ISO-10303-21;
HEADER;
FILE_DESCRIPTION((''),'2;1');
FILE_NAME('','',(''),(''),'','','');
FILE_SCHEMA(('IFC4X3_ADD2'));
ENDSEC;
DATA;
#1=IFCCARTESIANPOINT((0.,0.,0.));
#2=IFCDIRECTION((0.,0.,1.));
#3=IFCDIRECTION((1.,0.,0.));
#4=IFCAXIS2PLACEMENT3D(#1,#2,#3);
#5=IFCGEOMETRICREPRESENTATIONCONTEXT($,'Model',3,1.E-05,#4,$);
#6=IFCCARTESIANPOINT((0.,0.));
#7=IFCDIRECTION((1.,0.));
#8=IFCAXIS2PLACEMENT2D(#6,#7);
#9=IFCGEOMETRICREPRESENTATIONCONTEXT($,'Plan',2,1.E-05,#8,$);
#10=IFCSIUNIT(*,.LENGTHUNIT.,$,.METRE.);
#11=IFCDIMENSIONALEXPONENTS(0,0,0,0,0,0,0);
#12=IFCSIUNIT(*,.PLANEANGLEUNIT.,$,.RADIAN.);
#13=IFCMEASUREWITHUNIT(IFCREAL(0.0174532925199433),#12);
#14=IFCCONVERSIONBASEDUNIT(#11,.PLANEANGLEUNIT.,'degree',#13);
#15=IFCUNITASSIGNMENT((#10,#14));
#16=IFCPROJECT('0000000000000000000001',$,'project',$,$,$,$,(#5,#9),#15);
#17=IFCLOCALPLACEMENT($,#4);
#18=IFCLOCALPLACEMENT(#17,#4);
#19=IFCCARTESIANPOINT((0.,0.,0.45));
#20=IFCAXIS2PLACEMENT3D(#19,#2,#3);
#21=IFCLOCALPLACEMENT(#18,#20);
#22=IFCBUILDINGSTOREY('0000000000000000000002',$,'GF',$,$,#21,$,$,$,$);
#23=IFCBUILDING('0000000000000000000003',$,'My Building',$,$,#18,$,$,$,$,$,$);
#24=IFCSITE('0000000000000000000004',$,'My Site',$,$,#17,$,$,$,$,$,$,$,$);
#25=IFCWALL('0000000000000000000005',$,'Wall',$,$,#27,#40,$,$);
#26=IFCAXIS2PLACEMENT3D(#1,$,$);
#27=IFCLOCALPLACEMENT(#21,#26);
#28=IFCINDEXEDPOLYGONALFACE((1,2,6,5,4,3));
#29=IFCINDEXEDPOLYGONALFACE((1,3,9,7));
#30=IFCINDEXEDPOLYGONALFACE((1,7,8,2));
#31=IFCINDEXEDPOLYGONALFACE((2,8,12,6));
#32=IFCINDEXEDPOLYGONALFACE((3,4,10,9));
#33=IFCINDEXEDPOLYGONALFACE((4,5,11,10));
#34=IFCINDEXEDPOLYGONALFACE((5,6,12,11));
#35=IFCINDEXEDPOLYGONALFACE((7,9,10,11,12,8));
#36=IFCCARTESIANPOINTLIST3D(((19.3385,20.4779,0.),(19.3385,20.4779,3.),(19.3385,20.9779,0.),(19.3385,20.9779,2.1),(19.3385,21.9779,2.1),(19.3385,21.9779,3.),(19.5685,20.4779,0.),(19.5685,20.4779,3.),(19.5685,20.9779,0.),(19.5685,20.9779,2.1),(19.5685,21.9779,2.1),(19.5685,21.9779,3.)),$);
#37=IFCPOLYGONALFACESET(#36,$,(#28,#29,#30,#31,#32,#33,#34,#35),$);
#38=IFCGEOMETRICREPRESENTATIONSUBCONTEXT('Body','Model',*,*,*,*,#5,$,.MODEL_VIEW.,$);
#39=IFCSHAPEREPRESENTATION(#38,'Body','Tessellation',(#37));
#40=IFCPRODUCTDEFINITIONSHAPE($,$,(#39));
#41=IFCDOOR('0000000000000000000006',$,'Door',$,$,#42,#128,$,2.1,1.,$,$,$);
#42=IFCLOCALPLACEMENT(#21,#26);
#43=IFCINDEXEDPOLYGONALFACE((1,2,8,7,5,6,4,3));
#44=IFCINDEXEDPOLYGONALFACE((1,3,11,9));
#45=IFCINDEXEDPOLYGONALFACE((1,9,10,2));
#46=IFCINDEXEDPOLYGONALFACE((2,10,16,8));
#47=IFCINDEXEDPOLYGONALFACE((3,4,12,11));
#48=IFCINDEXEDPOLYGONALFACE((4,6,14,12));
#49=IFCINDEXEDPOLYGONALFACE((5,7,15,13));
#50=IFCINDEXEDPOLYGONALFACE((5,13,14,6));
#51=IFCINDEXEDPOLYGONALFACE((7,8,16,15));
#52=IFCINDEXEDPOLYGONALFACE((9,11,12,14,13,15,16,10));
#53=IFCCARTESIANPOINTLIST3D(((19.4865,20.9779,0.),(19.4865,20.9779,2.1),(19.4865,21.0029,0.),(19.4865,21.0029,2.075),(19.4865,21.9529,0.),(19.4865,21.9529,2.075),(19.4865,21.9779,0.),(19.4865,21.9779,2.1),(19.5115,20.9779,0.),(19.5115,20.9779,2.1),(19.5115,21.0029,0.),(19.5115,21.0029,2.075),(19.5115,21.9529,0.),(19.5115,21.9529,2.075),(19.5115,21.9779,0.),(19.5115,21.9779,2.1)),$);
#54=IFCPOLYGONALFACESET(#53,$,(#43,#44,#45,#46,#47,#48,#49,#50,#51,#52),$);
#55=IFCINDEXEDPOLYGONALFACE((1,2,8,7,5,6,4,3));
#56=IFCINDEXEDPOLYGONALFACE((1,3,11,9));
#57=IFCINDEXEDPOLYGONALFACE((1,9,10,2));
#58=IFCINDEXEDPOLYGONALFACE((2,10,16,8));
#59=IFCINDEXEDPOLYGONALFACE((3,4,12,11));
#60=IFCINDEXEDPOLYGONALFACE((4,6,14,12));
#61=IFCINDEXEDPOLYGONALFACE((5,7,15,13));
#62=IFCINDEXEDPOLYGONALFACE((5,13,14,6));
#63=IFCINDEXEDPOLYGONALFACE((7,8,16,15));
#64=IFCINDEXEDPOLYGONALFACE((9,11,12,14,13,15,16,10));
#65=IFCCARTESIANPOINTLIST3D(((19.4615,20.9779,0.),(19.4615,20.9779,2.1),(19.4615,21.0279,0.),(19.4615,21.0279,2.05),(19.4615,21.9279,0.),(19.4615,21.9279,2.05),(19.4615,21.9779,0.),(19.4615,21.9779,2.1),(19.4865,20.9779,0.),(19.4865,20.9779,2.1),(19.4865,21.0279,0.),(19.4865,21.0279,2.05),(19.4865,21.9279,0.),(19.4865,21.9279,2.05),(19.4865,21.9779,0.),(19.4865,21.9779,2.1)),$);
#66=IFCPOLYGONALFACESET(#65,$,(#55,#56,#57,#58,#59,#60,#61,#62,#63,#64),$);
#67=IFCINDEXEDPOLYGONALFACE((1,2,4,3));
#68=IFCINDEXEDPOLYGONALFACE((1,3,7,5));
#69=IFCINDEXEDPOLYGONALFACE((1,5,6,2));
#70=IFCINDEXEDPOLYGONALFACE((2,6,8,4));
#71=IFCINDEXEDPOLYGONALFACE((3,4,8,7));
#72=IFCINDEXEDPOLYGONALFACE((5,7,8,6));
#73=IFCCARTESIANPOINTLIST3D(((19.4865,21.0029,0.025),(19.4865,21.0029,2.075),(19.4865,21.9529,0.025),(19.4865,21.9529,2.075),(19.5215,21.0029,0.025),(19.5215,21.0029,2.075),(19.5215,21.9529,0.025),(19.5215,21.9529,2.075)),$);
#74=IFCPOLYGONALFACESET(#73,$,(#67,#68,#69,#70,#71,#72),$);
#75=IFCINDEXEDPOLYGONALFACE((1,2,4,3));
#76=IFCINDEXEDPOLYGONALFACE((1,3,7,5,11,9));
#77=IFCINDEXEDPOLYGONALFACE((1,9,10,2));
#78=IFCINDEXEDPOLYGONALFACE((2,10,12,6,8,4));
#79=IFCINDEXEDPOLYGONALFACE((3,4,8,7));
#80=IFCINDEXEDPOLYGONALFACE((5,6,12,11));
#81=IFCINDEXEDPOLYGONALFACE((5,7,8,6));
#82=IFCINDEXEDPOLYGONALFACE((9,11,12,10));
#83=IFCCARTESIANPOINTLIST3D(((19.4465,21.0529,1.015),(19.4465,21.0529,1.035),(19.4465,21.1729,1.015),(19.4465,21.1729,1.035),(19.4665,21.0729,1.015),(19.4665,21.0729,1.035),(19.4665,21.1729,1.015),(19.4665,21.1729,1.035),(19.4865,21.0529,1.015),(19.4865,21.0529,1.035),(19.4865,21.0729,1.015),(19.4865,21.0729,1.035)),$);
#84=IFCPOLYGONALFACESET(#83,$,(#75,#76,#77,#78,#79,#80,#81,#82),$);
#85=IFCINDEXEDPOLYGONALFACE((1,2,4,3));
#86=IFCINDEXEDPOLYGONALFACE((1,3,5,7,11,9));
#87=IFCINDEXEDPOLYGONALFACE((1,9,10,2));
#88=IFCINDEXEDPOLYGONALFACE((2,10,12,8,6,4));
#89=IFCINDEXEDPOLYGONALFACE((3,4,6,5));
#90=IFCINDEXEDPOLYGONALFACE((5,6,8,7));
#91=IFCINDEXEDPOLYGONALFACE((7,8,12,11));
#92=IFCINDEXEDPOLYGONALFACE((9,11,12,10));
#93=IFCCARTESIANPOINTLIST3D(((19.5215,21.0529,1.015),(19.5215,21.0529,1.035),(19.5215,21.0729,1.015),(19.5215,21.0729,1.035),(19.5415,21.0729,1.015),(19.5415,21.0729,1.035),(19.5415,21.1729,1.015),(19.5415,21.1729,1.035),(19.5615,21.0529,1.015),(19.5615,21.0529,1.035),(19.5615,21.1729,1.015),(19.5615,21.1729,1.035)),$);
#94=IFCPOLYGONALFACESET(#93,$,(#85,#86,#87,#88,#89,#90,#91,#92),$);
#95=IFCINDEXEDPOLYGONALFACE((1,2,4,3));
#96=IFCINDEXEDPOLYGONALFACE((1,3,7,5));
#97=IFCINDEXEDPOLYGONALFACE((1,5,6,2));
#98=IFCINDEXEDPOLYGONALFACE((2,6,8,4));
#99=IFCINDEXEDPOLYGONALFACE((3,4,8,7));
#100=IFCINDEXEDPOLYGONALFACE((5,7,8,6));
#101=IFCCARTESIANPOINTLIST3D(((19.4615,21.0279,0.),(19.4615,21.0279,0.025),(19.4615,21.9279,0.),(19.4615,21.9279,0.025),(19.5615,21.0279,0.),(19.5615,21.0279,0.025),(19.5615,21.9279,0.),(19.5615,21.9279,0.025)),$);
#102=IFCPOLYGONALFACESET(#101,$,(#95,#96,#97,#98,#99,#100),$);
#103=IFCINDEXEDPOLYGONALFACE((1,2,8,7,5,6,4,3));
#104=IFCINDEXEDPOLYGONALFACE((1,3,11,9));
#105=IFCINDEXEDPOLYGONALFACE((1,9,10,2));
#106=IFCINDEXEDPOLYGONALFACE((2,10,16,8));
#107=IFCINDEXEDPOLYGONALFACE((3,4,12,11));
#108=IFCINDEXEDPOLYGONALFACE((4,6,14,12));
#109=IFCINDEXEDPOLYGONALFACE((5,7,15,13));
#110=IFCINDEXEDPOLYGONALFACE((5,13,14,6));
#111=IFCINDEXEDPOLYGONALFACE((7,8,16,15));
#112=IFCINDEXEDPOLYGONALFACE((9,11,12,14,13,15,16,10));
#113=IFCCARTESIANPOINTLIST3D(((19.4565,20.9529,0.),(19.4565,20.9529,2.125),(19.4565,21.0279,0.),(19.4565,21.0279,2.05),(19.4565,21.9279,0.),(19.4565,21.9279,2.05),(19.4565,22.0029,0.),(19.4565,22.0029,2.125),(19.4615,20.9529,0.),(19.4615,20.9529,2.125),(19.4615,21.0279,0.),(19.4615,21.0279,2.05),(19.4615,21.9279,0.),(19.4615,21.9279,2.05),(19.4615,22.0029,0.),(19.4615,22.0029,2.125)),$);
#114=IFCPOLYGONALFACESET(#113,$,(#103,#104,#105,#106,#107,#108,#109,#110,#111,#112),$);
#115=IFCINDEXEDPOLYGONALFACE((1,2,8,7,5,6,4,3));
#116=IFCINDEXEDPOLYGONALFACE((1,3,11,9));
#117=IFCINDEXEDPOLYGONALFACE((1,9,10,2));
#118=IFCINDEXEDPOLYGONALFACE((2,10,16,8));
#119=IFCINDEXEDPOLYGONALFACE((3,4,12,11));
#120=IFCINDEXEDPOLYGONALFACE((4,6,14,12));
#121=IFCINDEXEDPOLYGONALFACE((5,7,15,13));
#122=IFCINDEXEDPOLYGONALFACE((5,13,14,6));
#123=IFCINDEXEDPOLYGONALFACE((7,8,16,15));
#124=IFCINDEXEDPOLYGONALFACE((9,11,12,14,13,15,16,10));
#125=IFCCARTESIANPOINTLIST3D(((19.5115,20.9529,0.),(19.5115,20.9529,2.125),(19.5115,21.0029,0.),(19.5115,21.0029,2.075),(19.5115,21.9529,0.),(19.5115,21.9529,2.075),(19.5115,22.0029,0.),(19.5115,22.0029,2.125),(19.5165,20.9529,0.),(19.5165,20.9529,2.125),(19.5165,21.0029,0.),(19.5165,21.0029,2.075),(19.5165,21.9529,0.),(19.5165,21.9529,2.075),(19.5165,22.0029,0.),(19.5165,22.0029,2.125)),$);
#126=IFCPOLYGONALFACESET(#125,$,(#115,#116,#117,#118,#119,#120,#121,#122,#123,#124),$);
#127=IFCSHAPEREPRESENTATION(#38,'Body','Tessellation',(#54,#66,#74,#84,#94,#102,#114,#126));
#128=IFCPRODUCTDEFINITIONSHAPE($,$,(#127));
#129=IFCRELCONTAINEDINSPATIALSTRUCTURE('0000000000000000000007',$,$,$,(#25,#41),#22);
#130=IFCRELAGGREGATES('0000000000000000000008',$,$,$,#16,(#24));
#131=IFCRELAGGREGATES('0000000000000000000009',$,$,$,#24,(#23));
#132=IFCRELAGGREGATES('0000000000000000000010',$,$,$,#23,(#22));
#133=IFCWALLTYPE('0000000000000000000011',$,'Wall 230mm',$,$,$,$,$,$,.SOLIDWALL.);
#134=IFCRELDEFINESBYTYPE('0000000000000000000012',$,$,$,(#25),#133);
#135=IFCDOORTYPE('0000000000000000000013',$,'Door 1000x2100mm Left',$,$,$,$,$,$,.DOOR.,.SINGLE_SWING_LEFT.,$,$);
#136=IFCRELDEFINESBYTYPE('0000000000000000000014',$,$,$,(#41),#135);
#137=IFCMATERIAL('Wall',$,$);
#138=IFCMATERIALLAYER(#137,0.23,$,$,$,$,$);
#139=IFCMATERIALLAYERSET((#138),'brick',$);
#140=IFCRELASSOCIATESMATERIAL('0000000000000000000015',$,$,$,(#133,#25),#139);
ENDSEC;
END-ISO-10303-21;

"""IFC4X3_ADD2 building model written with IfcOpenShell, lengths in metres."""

from ifc_helpers import new_model, entity, si_unit, converted_unit, frame, origin_with_axes, origin_2d_with_axis, place, context, subcontext, project, spatial, line, indexed_curve, outline, extrude, shape, source, transform, mapped, material, layer, layer_set, layer_usage, type_object, type_shapes, element, fill, save


model = new_model("IFC4X3_ADD2")

# Units and contexts
model_context = context("Model", 3, precision=1e-05, world=origin_with_axes())
plan_context = context("Plan", 2, precision=1e-05, world=origin_2d_with_axis())
body_context_1 = subcontext(model_context, "Body", "Model", "MODEL_VIEW")
body_context_2 = subcontext(plan_context, "Body", "Plan", "PLAN_VIEW")
ifc_project = project(units=[si_unit("LENGTHUNIT", "METRE"), converted_unit("PLANEANGLEUNIT", "degree", entity("IfcReal", 0.0174532925199433), si_unit("PLANEANGLEUNIT", "RADIAN"), dimensions=[0, 0, 0, 0, 0, 0, 0])], contexts=[model_context, plan_context])

# Site, building, storey
site_placement = place(None, origin_with_axes())
site = spatial("IfcSite", under=ifc_project, at=site_placement, Name="My Site")
building_placement = place(site_placement, origin_with_axes())
building = spatial("IfcBuilding", under=site, at=building_placement, Name="My Building")
storey_placement = place(building_placement, frame((0.0, 0.0, 0.45), z_axis=(0.0, 0.0, 1.0), x_axis=(1.0, 0.0, 0.0)))
storey = spatial("IfcBuildingStorey", under=building, at=storey_placement, Name="GF")

# Shared definitions
ifc_material_1 = material(Name="Wall")
ifc_layer = layer(ifc_material_1, 0.23)
ifc_layer_set = layer_set([ifc_layer], Name="brick")
wall_type = type_object("IfcWallType", Name="Wall 230mm", PredefinedType="SOLIDWALL", material=ifc_layer_set)

# Shared definitions
shared_shape_1 = source(origin_with_axes(), body_context_1, "Body", "SweptSolid", [
    extrude(outline(indexed_curve([(0.0, 0.0), (1.0, 0.0), (1.0, 2.1), (0.0, 2.1)], segments=[line(1, 2, 3, 4, 1)])), frame((0.0, -0.6, 0.0), z_axis=(0.0, -1.0, 0.0), x_axis=(1.0, 0.0, 0.0)), (0.0, 0.0, -1.0), 1.2),
])
door_type_1 = type_object("IfcDoorType", Name="Door 1000x2100mm Left", OperationType="SINGLE_SWING_LEFT", PredefinedType="DOOR")
shared_shape_2 = source(origin_with_axes(), body_context_1, "Body", "SweptSolid", [
    extrude(outline(indexed_curve([(0.0, 0.0), (0.0, 2.1), (1.0, 2.1), (1.0, 0.0), (0.975, 0.0), (0.975, 2.075), (0.025, 2.075), (0.025, 0.0)], segments=[line(1, 2, 3, 4, 5, 6, 7, 8, 1)])), frame((0.0, 0.025, 0.0), z_axis=(0.0, -1.0, 0.0), x_axis=(1.0, 0.0, 0.0)), (0.0, 0.0, -1.0), 0.025),
    extrude(outline(indexed_curve([(0.0, 0.0), (0.0, 2.1), (1.0, 2.1), (1.0, 0.0), (0.95, 0.0), (0.95, 2.05), (0.05, 2.05), (0.05, 0.0)], segments=[line(1, 2, 3, 4, 5, 6, 7, 8, 1)])), frame((0.0, 0.0, 0.0), z_axis=(0.0, -1.0, 0.0), x_axis=(1.0, 0.0, 0.0)), (0.0, 0.0, -1.0), 0.025),
    extrude(outline(indexed_curve([(0.0, 0.0), (0.95, 0.0), (0.95, 0.035), (0.0, 0.035)], segments=[line(1, 2, 3, 4, 1)])), frame((0.025, 0.025, 0.025), z_axis=(0.0, 0.0, 1.0), x_axis=(1.0, 0.0, 0.0)), (0.0, 0.0, 1.0), 2.05),
    extrude(outline(indexed_curve([(0.0, 0.0), (0.0, -0.04), (-0.12, -0.04), (-0.12, -0.02), (-0.02, -0.02), (-0.02, 0.0)], segments=[line(1, 2, 3, 4, 5, 6, 1)])), frame((0.925, 0.025, 1.015), z_axis=(0.0, 0.0, 1.0), x_axis=(1.0, 0.0, 0.0)), (0.0, 0.0, 1.0), 0.02),
    extrude(outline(indexed_curve([(0.0, 0.0), (0.0, 0.04), (-0.12, 0.04), (-0.12, 0.02), (-0.02, 0.02), (-0.02, 0.0)], segments=[line(1, 2, 3, 4, 5, 6, 1)])), frame((0.925, 0.06, 1.015), z_axis=(0.0, 0.0, 1.0), x_axis=(1.0, 0.0, 0.0)), (0.0, 0.0, 1.0), 0.02),
    extrude(outline(indexed_curve([(0.0, 0.0), (0.9, 0.0), (0.9, 0.1), (0.0, 0.1)], segments=[line(1, 2, 3, 4, 1)])), frame((0.05, 0.0, 0.0), z_axis=(0.0, 0.0, 1.0), x_axis=(1.0, 0.0, 0.0)), (0.0, 0.0, 1.0), 0.025),
    extrude(outline(indexed_curve([(0.0, 0.0), (0.0, 2.125), (1.05, 2.125), (1.05, 0.0), (0.975, 0.0), (0.975, 2.05), (0.075, 2.05), (0.075, 0.0)], segments=[line(1, 2, 3, 4, 5, 6, 7, 8, 1)])), frame((-0.025, -0.005, 0.0), z_axis=(0.0, -1.0, 0.0), x_axis=(1.0, 0.0, 0.0)), (0.0, 0.0, -1.0), 0.005),
    extrude(outline(indexed_curve([(0.0, 0.0), (0.0, 2.125), (1.05, 2.125), (1.05, 0.0), (1.0, 0.0), (1.0, 2.075), (0.05, 2.075), (0.05, 0.0)], segments=[line(1, 2, 3, 4, 5, 6, 7, 8, 1)])), frame((-0.025, 0.05, 0.0), z_axis=(0.0, -1.0, 0.0), x_axis=(1.0, 0.0, 0.0)), (0.0, 0.0, -1.0), 0.005),
])
shared_shape_3 = source(origin_with_axes(), body_context_2, "Body", "Curve2D", [
    entity("IfcIndexedPolyCurve", entity("IfcCartesianPointList2D", [[0.0, 0.0], [0.0, 0.05], [0.025, 0.05], [0.025, 0.025], [0.05, 0.025], [0.05, 0.0]]), [entity("IfcLineIndex", [1, 2, 3, 4, 5, 6, 1])]),
    entity("IfcIndexedPolyCurve", entity("IfcCartesianPointList2D", [[1.0, 0.0], [1.0, 0.05], [0.975, 0.05], [0.975, 0.025], [0.95, 0.025], [0.95, 0.0]]), [entity("IfcLineIndex", [1, 2, 3, 4, 5, 6, 1])]),
    entity("IfcTrimmedCurve", entity("IfcEllipse", entity("IfcAxis2Placement2D", entity("IfcCartesianPoint", [0.06, 0.05]), entity("IfcDirection", [1.0, 0.0])), 0.915, 0.95), [entity("IfcCartesianPoint", [0.975, 0.05])], [entity("IfcCartesianPoint", [0.06, 1.0])], True, "CARTESIAN"),
    entity("IfcIndexedPolyCurve", entity("IfcCartesianPointList2D", [[0.025, 0.05], [0.06, 0.05], [0.06, 1.0], [0.025, 1.0]]), [entity("IfcLineIndex", [1, 2, 3, 4, 1])]),
])
type_shapes(door_type_1, [shared_shape_2, shared_shape_3])

# Wall, opening, door
ifc_layer_usage_1 = layer_usage(ifc_layer_set, "AXIS2", "POSITIVE", 0.0)
wall_1_placement = place(storey_placement, frame((19.5685, 20.4779, 0.0), z_axis=(0.0, 0.0, 1.0), x_axis=(0.0, 1.0, 0.0)))
wall_1 = element("IfcWall", 1, at=wall_1_placement, inside=storey, type_object=wall_type, material=ifc_layer_usage_1, Name="Wall", context=body_context_1, shape_type="SweptSolid", body=[
    extrude(outline(indexed_curve([(0.0, 0.0), (0.0, 0.23), (1.5, 0.23), (1.5, 0.0), (0.0, 0.0)], self_intersect=False)), origin_with_axes(), (0.0, 0.0, 1.0), 3.0),
])
opening_1_placement = place(wall_1_placement, frame((1.5, 0.1071, 0.0), z_axis=(0.0, 0.0, 1.0), x_axis=(-1.0, 0.0, 0.0)))
opening_1 = element("IfcOpeningElement", 2, at=opening_1_placement, cuts=wall_1, PredefinedType="OPENING", context=body_context_1, shape_type="MappedRepresentation", body=[
    mapped(shared_shape_1, transform((0.0, 0.0, 0.0), x_axis=(1.0, 0.0, 0.0), y_axis=(0.0, 1.0, 0.0), z_axis=(0.0, 0.0, 1.0), scale=1.0)),
])
door_1_placement = place(opening_1_placement, frame((0.0, 0.0, 0.0), z_axis=(0.0, 0.0, 1.0), x_axis=(1.0, 0.0, 0.0)))
door_1 = element("IfcDoor", 3, at=door_1_placement, inside=storey, type_object=door_type_1, Name="Door", OverallHeight=2.1, OverallWidth=1.0, shapes=[
    shape(body_context_1, "Body", "MappedRepresentation", [mapped(shared_shape_2, transform((0.0, 0.0, 0.0), x_axis=(1.0, 0.0, 0.0), y_axis=(0.0, 1.0, 0.0), z_axis=(0.0, 0.0, 1.0), scale=1.0))]),
    shape(body_context_2, "Body", "MappedRepresentation", [mapped(shared_shape_3, transform((0.0, 0.0, 0.0), x_axis=(1.0, 0.0, 0.0), y_axis=(0.0, 1.0, 0.0), z_axis=(0.0, 0.0, 1.0), scale=1.0))]),
])
fill(opening_1, door_1)

save(model, "model.ifc")
